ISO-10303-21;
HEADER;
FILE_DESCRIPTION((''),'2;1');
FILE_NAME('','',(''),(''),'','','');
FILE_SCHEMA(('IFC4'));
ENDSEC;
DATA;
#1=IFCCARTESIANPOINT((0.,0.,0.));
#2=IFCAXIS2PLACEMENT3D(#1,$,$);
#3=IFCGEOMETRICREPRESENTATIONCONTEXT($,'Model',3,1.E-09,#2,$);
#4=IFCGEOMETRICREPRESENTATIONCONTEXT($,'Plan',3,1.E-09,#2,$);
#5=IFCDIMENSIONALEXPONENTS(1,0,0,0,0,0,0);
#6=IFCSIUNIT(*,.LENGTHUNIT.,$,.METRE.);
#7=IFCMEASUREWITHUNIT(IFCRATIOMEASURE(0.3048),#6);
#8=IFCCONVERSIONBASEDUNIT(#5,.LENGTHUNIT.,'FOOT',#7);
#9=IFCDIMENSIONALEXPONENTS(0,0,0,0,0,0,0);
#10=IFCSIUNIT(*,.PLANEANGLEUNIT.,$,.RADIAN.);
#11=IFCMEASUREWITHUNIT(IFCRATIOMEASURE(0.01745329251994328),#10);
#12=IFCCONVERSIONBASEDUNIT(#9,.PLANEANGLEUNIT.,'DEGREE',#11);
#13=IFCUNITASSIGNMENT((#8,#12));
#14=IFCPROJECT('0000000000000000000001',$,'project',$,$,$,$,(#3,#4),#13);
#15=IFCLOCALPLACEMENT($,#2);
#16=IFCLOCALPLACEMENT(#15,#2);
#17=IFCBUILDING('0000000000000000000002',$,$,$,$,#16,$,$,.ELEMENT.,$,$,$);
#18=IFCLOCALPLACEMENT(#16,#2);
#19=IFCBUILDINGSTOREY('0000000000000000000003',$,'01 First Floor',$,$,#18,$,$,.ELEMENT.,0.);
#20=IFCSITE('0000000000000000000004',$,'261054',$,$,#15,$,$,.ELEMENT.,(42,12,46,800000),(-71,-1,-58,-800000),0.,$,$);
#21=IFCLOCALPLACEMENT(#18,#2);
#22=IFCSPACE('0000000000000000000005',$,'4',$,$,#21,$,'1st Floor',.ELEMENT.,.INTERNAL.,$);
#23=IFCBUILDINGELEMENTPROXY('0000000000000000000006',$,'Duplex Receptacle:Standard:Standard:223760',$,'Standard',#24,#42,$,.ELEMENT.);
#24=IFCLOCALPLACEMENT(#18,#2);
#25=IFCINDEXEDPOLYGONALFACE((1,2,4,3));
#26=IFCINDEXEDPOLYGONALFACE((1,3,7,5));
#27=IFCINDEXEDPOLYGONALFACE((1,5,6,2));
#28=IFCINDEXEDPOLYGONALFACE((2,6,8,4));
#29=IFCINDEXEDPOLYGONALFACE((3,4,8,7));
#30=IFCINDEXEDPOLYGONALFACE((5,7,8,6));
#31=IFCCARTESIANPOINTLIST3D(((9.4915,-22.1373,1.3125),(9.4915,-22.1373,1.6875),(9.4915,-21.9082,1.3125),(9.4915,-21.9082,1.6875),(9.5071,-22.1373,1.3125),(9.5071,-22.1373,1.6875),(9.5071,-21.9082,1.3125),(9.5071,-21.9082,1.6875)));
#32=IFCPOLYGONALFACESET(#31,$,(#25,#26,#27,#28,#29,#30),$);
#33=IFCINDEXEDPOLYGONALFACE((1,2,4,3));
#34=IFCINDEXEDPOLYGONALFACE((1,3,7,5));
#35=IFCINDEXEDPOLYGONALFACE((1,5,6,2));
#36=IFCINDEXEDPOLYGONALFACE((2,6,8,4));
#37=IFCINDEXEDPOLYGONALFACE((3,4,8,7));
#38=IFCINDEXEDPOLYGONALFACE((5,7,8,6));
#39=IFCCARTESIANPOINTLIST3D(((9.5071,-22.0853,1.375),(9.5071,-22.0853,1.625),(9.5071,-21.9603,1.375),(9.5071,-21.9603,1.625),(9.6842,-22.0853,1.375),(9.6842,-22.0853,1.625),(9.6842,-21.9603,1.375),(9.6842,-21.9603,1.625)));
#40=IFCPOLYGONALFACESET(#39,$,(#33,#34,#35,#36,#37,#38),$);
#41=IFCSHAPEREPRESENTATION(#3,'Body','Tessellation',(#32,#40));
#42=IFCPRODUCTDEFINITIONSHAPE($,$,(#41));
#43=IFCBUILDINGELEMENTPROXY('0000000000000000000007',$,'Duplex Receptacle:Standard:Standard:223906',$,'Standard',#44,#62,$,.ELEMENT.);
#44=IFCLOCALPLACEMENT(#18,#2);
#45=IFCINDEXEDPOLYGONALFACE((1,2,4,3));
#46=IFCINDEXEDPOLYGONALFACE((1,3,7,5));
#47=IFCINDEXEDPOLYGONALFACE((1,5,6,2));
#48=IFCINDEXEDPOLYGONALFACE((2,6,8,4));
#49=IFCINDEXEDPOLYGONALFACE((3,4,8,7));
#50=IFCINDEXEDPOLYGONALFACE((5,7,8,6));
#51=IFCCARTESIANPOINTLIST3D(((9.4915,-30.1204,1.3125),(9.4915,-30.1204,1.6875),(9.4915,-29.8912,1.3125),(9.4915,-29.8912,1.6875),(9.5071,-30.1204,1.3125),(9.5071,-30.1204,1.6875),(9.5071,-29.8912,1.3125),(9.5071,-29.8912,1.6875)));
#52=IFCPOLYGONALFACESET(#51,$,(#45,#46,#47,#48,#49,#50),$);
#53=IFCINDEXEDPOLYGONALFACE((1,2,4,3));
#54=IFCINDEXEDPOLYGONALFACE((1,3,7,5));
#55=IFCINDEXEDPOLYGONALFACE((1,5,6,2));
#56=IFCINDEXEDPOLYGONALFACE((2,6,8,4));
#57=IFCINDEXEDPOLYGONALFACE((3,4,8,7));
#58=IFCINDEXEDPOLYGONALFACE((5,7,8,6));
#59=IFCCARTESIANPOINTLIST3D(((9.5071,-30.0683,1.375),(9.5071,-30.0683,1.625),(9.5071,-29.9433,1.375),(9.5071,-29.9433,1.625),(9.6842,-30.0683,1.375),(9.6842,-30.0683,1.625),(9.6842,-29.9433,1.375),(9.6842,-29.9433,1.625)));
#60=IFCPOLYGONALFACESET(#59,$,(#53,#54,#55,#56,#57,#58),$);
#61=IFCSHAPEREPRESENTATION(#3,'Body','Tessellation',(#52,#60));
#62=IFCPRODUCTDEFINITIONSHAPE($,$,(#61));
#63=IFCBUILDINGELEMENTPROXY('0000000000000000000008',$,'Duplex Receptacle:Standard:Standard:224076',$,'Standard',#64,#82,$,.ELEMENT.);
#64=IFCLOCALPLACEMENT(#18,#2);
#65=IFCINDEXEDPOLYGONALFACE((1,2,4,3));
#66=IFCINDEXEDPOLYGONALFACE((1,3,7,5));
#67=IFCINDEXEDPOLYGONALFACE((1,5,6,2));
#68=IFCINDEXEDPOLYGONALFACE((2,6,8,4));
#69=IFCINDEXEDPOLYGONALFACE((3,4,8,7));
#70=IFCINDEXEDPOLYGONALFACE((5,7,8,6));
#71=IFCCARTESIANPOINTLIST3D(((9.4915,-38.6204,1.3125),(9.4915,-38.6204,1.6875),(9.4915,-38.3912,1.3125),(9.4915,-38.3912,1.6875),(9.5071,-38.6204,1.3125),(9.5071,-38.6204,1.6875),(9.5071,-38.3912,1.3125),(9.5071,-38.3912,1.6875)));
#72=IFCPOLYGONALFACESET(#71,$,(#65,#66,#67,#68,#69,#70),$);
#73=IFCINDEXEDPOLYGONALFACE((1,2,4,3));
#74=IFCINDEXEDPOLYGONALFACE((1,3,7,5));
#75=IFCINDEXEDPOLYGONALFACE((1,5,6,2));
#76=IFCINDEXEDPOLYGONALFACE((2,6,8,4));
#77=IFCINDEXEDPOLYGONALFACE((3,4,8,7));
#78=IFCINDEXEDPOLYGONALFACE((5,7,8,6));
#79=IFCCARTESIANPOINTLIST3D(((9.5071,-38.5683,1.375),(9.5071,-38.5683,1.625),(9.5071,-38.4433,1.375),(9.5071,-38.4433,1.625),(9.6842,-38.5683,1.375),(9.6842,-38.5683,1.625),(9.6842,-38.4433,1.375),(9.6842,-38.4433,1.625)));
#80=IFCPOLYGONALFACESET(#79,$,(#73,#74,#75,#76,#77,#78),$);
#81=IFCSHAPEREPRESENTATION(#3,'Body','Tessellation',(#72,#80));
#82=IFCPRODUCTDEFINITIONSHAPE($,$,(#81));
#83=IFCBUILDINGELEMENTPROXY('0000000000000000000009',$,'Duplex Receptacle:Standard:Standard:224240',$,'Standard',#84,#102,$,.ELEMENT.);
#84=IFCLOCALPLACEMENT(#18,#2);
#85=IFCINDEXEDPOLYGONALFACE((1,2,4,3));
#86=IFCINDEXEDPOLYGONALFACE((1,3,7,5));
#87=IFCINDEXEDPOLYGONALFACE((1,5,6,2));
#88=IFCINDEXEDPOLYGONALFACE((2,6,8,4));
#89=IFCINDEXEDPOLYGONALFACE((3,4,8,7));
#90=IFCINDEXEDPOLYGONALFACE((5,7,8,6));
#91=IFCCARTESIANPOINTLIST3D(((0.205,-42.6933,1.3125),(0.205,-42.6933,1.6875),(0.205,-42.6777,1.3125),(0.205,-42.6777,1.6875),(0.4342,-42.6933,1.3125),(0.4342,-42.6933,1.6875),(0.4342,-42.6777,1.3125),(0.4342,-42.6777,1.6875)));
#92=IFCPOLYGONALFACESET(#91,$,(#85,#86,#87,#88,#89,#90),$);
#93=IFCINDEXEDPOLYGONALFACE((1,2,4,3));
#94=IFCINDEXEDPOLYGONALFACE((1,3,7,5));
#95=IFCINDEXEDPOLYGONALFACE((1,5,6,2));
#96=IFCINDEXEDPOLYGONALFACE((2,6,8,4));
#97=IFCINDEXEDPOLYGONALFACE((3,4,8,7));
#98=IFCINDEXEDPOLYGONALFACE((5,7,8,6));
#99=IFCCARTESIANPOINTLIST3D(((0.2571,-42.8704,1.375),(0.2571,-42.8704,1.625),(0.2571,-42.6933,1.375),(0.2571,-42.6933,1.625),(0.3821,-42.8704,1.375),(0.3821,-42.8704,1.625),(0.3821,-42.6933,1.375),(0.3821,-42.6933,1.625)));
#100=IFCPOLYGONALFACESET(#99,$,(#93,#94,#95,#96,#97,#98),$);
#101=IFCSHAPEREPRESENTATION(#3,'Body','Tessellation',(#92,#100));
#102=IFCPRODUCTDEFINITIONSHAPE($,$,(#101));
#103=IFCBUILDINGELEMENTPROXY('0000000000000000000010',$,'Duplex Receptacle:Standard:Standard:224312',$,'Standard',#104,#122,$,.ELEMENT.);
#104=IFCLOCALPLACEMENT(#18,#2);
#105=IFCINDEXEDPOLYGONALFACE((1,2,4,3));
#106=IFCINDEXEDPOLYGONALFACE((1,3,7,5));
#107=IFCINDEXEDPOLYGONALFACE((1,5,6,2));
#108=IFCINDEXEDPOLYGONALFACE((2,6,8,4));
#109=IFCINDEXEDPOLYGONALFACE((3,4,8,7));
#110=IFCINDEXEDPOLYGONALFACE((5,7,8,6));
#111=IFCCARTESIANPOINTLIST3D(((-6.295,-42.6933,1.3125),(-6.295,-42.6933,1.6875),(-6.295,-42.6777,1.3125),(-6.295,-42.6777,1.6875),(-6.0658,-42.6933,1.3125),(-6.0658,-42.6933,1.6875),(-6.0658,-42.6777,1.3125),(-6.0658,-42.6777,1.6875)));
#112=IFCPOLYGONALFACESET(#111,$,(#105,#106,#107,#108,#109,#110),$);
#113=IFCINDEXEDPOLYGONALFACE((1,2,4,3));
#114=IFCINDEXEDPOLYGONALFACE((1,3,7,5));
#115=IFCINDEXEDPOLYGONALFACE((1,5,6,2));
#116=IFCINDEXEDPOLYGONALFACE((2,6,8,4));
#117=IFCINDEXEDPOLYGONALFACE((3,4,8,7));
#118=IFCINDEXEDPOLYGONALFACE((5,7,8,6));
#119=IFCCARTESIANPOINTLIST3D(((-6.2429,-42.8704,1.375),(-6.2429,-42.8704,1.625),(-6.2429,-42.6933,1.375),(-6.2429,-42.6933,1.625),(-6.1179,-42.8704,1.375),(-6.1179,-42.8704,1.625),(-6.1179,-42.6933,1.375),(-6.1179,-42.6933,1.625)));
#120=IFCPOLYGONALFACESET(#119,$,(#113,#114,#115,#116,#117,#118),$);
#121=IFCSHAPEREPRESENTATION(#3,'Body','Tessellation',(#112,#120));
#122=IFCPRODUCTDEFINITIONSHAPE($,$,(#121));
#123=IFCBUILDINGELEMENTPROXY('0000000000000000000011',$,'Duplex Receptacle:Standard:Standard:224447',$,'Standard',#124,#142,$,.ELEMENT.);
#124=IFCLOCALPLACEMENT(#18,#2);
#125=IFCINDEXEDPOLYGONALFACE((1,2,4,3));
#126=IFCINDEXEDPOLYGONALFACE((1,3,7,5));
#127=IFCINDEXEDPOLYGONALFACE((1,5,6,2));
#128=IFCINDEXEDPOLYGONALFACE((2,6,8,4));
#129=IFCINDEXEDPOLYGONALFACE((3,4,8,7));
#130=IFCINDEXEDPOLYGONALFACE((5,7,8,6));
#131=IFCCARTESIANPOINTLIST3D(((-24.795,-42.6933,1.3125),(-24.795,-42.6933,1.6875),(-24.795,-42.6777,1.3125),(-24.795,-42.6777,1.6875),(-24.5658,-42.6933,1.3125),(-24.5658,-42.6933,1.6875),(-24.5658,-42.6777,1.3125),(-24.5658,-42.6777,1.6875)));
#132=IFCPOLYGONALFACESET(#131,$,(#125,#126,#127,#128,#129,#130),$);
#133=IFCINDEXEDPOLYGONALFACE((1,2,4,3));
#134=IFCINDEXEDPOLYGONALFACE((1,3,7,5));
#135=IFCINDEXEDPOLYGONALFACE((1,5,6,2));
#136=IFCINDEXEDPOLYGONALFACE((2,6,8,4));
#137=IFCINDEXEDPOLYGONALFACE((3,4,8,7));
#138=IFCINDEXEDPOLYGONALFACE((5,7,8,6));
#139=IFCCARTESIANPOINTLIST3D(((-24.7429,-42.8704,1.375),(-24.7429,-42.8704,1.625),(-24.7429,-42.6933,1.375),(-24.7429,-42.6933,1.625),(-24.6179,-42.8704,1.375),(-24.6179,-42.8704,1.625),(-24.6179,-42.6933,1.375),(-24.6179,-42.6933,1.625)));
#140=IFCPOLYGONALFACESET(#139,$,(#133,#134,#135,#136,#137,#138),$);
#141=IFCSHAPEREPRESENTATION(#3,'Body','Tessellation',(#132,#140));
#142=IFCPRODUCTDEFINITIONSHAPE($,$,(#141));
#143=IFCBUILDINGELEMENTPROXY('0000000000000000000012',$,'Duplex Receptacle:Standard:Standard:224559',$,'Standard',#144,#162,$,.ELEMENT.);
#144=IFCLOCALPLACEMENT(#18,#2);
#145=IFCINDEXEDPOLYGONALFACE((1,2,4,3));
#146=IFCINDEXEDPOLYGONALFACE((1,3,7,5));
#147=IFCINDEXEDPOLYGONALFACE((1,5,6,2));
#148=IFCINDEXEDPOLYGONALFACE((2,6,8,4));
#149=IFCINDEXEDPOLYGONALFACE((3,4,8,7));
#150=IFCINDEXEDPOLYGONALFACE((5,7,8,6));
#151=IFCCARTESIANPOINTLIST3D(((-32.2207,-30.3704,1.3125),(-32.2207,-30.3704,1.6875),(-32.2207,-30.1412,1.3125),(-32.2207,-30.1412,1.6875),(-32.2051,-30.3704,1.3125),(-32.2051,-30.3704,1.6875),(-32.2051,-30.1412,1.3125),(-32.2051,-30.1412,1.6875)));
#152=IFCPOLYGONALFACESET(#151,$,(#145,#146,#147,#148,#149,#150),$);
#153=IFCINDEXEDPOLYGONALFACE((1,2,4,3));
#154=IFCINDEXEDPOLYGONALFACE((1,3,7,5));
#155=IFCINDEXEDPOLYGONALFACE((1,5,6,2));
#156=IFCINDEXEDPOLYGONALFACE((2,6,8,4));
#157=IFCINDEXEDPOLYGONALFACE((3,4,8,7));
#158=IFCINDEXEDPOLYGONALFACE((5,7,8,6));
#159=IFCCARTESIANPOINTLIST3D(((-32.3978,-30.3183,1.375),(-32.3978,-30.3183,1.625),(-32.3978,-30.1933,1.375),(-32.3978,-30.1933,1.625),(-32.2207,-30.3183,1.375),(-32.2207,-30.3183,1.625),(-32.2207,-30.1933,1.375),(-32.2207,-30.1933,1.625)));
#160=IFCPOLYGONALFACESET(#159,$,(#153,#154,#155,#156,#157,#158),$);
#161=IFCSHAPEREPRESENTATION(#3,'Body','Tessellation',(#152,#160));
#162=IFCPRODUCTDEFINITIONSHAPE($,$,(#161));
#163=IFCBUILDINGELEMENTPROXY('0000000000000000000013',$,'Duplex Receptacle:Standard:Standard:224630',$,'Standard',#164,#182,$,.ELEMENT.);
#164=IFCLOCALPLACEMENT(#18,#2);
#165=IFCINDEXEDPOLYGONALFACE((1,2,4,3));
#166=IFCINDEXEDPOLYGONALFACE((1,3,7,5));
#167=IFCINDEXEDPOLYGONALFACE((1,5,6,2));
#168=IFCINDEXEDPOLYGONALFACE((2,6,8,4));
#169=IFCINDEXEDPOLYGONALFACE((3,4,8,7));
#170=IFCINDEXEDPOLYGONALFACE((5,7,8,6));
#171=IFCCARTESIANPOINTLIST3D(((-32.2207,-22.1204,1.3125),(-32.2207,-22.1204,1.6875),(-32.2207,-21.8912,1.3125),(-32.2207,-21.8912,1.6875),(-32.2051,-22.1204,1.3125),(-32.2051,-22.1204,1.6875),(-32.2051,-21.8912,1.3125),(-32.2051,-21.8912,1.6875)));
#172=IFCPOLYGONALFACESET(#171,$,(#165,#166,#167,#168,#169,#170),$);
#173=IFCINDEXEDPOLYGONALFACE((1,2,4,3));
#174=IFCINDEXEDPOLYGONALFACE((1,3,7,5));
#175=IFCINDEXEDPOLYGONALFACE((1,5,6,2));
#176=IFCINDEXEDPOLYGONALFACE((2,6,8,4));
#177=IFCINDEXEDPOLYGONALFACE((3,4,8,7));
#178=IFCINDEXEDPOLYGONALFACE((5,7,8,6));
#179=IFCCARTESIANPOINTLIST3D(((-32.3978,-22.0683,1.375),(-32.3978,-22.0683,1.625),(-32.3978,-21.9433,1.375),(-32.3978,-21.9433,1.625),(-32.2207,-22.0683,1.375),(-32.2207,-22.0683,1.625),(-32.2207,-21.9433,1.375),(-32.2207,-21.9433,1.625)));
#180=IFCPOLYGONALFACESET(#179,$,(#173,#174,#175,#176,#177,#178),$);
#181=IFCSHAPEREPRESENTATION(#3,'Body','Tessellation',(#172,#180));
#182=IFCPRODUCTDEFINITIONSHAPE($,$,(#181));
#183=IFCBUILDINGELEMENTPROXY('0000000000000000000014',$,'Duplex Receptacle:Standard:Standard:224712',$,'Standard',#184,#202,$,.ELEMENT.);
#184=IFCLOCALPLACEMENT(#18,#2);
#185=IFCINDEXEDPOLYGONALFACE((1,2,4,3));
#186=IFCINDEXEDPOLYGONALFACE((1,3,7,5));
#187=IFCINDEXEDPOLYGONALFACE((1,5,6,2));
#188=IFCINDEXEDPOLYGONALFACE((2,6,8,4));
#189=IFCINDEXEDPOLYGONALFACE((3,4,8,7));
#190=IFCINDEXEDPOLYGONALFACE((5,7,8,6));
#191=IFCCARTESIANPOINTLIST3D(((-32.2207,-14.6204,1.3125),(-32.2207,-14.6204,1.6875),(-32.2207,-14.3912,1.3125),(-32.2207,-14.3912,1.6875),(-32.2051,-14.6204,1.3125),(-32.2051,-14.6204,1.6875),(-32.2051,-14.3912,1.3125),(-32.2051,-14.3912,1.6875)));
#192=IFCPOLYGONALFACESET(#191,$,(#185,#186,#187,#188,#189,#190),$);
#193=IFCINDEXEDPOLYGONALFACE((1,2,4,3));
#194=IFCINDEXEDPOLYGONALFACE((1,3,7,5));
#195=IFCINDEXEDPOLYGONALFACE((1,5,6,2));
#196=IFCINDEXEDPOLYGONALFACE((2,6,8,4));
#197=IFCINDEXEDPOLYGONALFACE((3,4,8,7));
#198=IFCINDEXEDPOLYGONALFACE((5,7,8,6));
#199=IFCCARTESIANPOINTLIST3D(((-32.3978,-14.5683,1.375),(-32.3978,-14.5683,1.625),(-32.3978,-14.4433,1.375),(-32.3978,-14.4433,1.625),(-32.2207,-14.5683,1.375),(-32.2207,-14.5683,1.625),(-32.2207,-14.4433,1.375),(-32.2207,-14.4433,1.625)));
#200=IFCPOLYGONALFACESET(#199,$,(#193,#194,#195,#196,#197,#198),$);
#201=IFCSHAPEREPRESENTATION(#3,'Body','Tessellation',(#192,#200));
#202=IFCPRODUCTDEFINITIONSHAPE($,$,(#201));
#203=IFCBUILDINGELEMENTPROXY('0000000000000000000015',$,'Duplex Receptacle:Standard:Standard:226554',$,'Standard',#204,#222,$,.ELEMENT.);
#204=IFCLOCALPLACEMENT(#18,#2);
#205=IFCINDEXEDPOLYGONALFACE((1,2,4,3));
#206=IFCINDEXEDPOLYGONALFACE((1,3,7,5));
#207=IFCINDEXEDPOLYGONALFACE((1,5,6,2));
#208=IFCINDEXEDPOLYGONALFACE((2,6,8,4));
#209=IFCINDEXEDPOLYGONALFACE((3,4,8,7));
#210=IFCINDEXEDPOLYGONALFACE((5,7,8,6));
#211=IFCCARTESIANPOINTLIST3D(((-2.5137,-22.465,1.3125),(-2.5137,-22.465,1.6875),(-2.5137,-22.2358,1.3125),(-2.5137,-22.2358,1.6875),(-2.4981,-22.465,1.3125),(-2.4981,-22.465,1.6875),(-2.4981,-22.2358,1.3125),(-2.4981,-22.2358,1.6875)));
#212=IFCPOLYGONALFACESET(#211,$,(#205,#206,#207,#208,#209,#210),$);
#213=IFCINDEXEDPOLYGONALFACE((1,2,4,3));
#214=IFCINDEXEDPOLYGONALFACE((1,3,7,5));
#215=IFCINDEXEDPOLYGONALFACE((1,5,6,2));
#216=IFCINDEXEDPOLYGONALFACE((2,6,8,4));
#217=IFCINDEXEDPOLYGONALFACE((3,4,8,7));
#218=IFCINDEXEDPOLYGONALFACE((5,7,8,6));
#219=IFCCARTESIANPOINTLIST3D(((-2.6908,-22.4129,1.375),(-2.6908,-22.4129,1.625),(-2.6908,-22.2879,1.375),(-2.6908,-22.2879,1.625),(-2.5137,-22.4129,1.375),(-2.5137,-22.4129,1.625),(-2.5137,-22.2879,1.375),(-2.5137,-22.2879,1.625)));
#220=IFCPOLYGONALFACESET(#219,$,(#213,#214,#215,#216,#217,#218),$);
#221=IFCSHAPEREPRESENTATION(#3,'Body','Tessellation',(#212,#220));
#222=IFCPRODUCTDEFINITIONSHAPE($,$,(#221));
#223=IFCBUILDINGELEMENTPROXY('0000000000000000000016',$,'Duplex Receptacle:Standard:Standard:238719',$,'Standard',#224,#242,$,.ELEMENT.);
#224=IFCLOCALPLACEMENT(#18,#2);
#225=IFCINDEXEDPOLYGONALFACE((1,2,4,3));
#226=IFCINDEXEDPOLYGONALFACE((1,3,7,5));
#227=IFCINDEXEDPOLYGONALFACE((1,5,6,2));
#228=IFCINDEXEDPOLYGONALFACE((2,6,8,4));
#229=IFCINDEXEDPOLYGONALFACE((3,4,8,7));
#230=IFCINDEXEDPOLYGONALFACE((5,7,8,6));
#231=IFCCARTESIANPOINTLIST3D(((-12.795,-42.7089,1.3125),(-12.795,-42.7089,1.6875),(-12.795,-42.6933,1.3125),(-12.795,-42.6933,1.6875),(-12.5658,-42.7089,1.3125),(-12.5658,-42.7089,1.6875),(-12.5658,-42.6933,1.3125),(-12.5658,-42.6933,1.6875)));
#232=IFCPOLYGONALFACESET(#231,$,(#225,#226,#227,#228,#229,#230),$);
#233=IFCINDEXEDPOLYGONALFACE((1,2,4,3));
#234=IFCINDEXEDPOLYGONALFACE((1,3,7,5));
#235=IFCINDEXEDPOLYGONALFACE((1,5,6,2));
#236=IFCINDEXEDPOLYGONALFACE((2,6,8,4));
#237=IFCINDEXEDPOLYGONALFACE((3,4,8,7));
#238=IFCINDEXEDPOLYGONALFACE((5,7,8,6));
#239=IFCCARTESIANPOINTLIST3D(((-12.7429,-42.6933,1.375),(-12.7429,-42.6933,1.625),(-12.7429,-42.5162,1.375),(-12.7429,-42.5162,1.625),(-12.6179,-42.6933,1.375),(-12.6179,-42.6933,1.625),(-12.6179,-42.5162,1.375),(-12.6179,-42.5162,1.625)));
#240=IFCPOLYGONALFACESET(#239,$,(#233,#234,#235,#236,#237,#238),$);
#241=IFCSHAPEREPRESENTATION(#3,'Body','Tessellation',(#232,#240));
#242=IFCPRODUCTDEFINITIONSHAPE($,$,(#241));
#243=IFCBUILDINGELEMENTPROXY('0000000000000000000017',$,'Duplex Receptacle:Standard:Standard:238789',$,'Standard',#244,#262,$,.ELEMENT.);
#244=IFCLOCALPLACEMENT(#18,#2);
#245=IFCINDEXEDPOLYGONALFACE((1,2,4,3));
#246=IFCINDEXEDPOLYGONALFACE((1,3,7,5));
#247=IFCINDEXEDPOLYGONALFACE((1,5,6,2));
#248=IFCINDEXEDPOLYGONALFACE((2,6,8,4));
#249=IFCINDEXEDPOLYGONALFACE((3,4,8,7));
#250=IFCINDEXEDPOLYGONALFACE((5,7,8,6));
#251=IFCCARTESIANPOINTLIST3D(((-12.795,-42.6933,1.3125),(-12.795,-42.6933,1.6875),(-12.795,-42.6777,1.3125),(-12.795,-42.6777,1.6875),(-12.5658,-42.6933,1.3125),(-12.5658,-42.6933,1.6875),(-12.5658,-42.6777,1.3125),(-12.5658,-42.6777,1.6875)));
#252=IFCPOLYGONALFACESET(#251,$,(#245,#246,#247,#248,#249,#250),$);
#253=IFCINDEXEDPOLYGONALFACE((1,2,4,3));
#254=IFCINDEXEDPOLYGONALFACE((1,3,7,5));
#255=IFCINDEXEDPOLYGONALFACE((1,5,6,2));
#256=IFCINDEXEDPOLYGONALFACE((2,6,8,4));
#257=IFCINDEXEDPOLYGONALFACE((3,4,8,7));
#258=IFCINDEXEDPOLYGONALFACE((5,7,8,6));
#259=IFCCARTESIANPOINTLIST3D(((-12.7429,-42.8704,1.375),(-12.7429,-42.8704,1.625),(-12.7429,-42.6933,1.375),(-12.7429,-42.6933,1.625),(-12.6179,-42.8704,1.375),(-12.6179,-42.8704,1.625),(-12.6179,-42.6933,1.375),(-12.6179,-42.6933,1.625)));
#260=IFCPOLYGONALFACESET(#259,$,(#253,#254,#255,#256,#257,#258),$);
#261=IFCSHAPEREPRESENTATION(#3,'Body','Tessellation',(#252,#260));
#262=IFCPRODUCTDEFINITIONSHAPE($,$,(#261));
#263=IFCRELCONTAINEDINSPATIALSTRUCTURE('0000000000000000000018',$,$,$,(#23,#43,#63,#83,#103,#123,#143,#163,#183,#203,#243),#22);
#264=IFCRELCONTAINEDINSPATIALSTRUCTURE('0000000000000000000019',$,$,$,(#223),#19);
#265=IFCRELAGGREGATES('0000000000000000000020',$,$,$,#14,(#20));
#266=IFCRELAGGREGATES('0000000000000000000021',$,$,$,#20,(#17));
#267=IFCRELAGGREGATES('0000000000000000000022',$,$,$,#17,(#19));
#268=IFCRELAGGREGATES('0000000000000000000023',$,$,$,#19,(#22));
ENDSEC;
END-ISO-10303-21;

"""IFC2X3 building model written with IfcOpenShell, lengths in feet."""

from ifc_helpers import new_model, entity, si_unit, converted_unit, frame, origin, origin_2d_with_axis, place, context, project, spatial, rectangle, extrude, source, transform, mapped, element, save


model = new_model("IFC2X3")

# Units and contexts
model_context = context("Model", 3, precision=1e-09, world=origin())
plan_context = context("Plan", 3, precision=1e-09, world=origin())
ifc_project = project(units=[converted_unit("LENGTHUNIT", "FOOT", entity("IfcRatioMeasure", 0.3048), si_unit("LENGTHUNIT", "METRE"), dimensions=[1, 0, 0, 0, 0, 0, 0]), converted_unit("PLANEANGLEUNIT", "DEGREE", entity("IfcRatioMeasure", 0.01745329251994328), si_unit("PLANEANGLEUNIT", "RADIAN"), dimensions=[0, 0, 0, 0, 0, 0, 0])], contexts=[model_context, plan_context])

# Site, building, storey
site_placement = place(None, origin())
site = spatial("IfcSite", under=ifc_project, at=site_placement, Name="261054", CompositionType="ELEMENT", RefLatitude=(42, 12, 46, 800000), RefLongitude=(-71, -1, -58, -800000), RefElevation=0.0)
building_placement = place(site_placement, origin())
building = spatial("IfcBuilding", under=site, at=building_placement, CompositionType="ELEMENT")
storey_placement = place(building_placement, origin())
storey = spatial("IfcBuildingStorey", under=building, at=storey_placement, Name="01 First Floor", CompositionType="ELEMENT", Elevation=0.0)

# Shared definitions
space_placement = place(storey_placement, origin())
space = spatial("IfcSpace", under=storey, at=space_placement, Name="4", LongName="1st Floor", CompositionType="ELEMENT", InteriorOrExteriorSpace="INTERNAL")

# Building element proxies
shared_shape_1 = source(origin(), model_context, "Body", "SweptSolid", [
    extrude(rectangle(XDim=0.2292, YDim=0.375, at=origin_2d_with_axis()), frame((0.0, 0.0, 0.0), z_axis=(0.0, 0.0, 1.0), x_axis=(-1.0, 0.0, 0.0)), (0.0, 0.0, 1.0), 0.0156),
    extrude(rectangle(XDim=0.125, YDim=0.25, at=origin_2d_with_axis()), frame((0.0, 0.0, -0.1771), z_axis=(0.0, 0.0, 1.0), x_axis=(-1.0, 0.0, 0.0)), (0.0, 0.0, 1.0), 0.1771),
])
for number, where, z_axis, x_axis, name in (
    (1, (9.5071, -22.0228, 1.5), (-1.0, 0.0, 0.0), (0.0, -1.0, 0.0), "Duplex Receptacle:Standard:Standard:223760"),
    (2, (9.5071, -30.0058, 1.5), (-1.0, 0.0, 0.0), (0.0, -1.0, 0.0), "Duplex Receptacle:Standard:Standard:223906"),
    (3, (9.5071, -38.5058, 1.5), (-1.0, 0.0, 0.0), (0.0, -1.0, 0.0), "Duplex Receptacle:Standard:Standard:224076"),
    (4, (0.3196, -42.6933, 1.5), (0.0, 1.0, 0.0), (-1.0, 0.0, 0.0), "Duplex Receptacle:Standard:Standard:224240"),
    (5, (-6.1804, -42.6933, 1.5), (0.0, 1.0, 0.0), (-1.0, 0.0, 0.0), "Duplex Receptacle:Standard:Standard:224312"),
    (6, (-24.6804, -42.6933, 1.5), (0.0, 1.0, 0.0), (-1.0, 0.0, 0.0), "Duplex Receptacle:Standard:Standard:224447"),
    (7, (-32.2207, -30.2558, 1.5), (1.0, 0.0, 0.0), (0.0, 1.0, 0.0), "Duplex Receptacle:Standard:Standard:224559"),
    (8, (-32.2207, -22.0058, 1.5), (1.0, 0.0, 0.0), (0.0, 1.0, 0.0), "Duplex Receptacle:Standard:Standard:224630"),
    (9, (-32.2207, -14.5058, 1.5), (1.0, 0.0, 0.0), (0.0, 1.0, 0.0), "Duplex Receptacle:Standard:Standard:224712"),
    (10, (-2.5137, -22.3504, 1.5), (1.0, 0.0, 0.0), (0.0, 1.0, 0.0), "Duplex Receptacle:Standard:Standard:226554"),
):
    element("IfcBuildingElementProxy", number, at=place(space_placement, frame(where, z_axis=z_axis, x_axis=x_axis)), inside=space, Name=name, ObjectType="Standard", CompositionType="ELEMENT", context=model_context, shape_type="MappedRepresentation", body=[
        mapped(shared_shape_1, transform((0.0, 0.0, 0.0), scale=1.0)),
    ])
proxy_1_placement = place(storey_placement, frame((-12.6804, -42.6933, 1.5), z_axis=(0.0, -1.0, 0.0), x_axis=(-1.0, 0.0, 0.0)))
element("IfcBuildingElementProxy", 11, at=proxy_1_placement, inside=storey, Name="Duplex Receptacle:Standard:Standard:238719", ObjectType="Standard", CompositionType="ELEMENT", context=model_context, shape_type="MappedRepresentation", body=[
    mapped(shared_shape_1, transform((0.0, 0.0, 0.0), scale=1.0)),
])
proxy_2_placement = place(space_placement, frame((-12.6804, -42.6933, 1.5), z_axis=(0.0, 1.0, 0.0), x_axis=(-1.0, 0.0, 0.0)))
element("IfcBuildingElementProxy", 12, at=proxy_2_placement, inside=space, Name="Duplex Receptacle:Standard:Standard:238789", ObjectType="Standard", CompositionType="ELEMENT", context=model_context, shape_type="MappedRepresentation", body=[
    mapped(shared_shape_1, transform((0.0, 0.0, 0.0), scale=1.0)),
])

save(model, "model.ifc")
